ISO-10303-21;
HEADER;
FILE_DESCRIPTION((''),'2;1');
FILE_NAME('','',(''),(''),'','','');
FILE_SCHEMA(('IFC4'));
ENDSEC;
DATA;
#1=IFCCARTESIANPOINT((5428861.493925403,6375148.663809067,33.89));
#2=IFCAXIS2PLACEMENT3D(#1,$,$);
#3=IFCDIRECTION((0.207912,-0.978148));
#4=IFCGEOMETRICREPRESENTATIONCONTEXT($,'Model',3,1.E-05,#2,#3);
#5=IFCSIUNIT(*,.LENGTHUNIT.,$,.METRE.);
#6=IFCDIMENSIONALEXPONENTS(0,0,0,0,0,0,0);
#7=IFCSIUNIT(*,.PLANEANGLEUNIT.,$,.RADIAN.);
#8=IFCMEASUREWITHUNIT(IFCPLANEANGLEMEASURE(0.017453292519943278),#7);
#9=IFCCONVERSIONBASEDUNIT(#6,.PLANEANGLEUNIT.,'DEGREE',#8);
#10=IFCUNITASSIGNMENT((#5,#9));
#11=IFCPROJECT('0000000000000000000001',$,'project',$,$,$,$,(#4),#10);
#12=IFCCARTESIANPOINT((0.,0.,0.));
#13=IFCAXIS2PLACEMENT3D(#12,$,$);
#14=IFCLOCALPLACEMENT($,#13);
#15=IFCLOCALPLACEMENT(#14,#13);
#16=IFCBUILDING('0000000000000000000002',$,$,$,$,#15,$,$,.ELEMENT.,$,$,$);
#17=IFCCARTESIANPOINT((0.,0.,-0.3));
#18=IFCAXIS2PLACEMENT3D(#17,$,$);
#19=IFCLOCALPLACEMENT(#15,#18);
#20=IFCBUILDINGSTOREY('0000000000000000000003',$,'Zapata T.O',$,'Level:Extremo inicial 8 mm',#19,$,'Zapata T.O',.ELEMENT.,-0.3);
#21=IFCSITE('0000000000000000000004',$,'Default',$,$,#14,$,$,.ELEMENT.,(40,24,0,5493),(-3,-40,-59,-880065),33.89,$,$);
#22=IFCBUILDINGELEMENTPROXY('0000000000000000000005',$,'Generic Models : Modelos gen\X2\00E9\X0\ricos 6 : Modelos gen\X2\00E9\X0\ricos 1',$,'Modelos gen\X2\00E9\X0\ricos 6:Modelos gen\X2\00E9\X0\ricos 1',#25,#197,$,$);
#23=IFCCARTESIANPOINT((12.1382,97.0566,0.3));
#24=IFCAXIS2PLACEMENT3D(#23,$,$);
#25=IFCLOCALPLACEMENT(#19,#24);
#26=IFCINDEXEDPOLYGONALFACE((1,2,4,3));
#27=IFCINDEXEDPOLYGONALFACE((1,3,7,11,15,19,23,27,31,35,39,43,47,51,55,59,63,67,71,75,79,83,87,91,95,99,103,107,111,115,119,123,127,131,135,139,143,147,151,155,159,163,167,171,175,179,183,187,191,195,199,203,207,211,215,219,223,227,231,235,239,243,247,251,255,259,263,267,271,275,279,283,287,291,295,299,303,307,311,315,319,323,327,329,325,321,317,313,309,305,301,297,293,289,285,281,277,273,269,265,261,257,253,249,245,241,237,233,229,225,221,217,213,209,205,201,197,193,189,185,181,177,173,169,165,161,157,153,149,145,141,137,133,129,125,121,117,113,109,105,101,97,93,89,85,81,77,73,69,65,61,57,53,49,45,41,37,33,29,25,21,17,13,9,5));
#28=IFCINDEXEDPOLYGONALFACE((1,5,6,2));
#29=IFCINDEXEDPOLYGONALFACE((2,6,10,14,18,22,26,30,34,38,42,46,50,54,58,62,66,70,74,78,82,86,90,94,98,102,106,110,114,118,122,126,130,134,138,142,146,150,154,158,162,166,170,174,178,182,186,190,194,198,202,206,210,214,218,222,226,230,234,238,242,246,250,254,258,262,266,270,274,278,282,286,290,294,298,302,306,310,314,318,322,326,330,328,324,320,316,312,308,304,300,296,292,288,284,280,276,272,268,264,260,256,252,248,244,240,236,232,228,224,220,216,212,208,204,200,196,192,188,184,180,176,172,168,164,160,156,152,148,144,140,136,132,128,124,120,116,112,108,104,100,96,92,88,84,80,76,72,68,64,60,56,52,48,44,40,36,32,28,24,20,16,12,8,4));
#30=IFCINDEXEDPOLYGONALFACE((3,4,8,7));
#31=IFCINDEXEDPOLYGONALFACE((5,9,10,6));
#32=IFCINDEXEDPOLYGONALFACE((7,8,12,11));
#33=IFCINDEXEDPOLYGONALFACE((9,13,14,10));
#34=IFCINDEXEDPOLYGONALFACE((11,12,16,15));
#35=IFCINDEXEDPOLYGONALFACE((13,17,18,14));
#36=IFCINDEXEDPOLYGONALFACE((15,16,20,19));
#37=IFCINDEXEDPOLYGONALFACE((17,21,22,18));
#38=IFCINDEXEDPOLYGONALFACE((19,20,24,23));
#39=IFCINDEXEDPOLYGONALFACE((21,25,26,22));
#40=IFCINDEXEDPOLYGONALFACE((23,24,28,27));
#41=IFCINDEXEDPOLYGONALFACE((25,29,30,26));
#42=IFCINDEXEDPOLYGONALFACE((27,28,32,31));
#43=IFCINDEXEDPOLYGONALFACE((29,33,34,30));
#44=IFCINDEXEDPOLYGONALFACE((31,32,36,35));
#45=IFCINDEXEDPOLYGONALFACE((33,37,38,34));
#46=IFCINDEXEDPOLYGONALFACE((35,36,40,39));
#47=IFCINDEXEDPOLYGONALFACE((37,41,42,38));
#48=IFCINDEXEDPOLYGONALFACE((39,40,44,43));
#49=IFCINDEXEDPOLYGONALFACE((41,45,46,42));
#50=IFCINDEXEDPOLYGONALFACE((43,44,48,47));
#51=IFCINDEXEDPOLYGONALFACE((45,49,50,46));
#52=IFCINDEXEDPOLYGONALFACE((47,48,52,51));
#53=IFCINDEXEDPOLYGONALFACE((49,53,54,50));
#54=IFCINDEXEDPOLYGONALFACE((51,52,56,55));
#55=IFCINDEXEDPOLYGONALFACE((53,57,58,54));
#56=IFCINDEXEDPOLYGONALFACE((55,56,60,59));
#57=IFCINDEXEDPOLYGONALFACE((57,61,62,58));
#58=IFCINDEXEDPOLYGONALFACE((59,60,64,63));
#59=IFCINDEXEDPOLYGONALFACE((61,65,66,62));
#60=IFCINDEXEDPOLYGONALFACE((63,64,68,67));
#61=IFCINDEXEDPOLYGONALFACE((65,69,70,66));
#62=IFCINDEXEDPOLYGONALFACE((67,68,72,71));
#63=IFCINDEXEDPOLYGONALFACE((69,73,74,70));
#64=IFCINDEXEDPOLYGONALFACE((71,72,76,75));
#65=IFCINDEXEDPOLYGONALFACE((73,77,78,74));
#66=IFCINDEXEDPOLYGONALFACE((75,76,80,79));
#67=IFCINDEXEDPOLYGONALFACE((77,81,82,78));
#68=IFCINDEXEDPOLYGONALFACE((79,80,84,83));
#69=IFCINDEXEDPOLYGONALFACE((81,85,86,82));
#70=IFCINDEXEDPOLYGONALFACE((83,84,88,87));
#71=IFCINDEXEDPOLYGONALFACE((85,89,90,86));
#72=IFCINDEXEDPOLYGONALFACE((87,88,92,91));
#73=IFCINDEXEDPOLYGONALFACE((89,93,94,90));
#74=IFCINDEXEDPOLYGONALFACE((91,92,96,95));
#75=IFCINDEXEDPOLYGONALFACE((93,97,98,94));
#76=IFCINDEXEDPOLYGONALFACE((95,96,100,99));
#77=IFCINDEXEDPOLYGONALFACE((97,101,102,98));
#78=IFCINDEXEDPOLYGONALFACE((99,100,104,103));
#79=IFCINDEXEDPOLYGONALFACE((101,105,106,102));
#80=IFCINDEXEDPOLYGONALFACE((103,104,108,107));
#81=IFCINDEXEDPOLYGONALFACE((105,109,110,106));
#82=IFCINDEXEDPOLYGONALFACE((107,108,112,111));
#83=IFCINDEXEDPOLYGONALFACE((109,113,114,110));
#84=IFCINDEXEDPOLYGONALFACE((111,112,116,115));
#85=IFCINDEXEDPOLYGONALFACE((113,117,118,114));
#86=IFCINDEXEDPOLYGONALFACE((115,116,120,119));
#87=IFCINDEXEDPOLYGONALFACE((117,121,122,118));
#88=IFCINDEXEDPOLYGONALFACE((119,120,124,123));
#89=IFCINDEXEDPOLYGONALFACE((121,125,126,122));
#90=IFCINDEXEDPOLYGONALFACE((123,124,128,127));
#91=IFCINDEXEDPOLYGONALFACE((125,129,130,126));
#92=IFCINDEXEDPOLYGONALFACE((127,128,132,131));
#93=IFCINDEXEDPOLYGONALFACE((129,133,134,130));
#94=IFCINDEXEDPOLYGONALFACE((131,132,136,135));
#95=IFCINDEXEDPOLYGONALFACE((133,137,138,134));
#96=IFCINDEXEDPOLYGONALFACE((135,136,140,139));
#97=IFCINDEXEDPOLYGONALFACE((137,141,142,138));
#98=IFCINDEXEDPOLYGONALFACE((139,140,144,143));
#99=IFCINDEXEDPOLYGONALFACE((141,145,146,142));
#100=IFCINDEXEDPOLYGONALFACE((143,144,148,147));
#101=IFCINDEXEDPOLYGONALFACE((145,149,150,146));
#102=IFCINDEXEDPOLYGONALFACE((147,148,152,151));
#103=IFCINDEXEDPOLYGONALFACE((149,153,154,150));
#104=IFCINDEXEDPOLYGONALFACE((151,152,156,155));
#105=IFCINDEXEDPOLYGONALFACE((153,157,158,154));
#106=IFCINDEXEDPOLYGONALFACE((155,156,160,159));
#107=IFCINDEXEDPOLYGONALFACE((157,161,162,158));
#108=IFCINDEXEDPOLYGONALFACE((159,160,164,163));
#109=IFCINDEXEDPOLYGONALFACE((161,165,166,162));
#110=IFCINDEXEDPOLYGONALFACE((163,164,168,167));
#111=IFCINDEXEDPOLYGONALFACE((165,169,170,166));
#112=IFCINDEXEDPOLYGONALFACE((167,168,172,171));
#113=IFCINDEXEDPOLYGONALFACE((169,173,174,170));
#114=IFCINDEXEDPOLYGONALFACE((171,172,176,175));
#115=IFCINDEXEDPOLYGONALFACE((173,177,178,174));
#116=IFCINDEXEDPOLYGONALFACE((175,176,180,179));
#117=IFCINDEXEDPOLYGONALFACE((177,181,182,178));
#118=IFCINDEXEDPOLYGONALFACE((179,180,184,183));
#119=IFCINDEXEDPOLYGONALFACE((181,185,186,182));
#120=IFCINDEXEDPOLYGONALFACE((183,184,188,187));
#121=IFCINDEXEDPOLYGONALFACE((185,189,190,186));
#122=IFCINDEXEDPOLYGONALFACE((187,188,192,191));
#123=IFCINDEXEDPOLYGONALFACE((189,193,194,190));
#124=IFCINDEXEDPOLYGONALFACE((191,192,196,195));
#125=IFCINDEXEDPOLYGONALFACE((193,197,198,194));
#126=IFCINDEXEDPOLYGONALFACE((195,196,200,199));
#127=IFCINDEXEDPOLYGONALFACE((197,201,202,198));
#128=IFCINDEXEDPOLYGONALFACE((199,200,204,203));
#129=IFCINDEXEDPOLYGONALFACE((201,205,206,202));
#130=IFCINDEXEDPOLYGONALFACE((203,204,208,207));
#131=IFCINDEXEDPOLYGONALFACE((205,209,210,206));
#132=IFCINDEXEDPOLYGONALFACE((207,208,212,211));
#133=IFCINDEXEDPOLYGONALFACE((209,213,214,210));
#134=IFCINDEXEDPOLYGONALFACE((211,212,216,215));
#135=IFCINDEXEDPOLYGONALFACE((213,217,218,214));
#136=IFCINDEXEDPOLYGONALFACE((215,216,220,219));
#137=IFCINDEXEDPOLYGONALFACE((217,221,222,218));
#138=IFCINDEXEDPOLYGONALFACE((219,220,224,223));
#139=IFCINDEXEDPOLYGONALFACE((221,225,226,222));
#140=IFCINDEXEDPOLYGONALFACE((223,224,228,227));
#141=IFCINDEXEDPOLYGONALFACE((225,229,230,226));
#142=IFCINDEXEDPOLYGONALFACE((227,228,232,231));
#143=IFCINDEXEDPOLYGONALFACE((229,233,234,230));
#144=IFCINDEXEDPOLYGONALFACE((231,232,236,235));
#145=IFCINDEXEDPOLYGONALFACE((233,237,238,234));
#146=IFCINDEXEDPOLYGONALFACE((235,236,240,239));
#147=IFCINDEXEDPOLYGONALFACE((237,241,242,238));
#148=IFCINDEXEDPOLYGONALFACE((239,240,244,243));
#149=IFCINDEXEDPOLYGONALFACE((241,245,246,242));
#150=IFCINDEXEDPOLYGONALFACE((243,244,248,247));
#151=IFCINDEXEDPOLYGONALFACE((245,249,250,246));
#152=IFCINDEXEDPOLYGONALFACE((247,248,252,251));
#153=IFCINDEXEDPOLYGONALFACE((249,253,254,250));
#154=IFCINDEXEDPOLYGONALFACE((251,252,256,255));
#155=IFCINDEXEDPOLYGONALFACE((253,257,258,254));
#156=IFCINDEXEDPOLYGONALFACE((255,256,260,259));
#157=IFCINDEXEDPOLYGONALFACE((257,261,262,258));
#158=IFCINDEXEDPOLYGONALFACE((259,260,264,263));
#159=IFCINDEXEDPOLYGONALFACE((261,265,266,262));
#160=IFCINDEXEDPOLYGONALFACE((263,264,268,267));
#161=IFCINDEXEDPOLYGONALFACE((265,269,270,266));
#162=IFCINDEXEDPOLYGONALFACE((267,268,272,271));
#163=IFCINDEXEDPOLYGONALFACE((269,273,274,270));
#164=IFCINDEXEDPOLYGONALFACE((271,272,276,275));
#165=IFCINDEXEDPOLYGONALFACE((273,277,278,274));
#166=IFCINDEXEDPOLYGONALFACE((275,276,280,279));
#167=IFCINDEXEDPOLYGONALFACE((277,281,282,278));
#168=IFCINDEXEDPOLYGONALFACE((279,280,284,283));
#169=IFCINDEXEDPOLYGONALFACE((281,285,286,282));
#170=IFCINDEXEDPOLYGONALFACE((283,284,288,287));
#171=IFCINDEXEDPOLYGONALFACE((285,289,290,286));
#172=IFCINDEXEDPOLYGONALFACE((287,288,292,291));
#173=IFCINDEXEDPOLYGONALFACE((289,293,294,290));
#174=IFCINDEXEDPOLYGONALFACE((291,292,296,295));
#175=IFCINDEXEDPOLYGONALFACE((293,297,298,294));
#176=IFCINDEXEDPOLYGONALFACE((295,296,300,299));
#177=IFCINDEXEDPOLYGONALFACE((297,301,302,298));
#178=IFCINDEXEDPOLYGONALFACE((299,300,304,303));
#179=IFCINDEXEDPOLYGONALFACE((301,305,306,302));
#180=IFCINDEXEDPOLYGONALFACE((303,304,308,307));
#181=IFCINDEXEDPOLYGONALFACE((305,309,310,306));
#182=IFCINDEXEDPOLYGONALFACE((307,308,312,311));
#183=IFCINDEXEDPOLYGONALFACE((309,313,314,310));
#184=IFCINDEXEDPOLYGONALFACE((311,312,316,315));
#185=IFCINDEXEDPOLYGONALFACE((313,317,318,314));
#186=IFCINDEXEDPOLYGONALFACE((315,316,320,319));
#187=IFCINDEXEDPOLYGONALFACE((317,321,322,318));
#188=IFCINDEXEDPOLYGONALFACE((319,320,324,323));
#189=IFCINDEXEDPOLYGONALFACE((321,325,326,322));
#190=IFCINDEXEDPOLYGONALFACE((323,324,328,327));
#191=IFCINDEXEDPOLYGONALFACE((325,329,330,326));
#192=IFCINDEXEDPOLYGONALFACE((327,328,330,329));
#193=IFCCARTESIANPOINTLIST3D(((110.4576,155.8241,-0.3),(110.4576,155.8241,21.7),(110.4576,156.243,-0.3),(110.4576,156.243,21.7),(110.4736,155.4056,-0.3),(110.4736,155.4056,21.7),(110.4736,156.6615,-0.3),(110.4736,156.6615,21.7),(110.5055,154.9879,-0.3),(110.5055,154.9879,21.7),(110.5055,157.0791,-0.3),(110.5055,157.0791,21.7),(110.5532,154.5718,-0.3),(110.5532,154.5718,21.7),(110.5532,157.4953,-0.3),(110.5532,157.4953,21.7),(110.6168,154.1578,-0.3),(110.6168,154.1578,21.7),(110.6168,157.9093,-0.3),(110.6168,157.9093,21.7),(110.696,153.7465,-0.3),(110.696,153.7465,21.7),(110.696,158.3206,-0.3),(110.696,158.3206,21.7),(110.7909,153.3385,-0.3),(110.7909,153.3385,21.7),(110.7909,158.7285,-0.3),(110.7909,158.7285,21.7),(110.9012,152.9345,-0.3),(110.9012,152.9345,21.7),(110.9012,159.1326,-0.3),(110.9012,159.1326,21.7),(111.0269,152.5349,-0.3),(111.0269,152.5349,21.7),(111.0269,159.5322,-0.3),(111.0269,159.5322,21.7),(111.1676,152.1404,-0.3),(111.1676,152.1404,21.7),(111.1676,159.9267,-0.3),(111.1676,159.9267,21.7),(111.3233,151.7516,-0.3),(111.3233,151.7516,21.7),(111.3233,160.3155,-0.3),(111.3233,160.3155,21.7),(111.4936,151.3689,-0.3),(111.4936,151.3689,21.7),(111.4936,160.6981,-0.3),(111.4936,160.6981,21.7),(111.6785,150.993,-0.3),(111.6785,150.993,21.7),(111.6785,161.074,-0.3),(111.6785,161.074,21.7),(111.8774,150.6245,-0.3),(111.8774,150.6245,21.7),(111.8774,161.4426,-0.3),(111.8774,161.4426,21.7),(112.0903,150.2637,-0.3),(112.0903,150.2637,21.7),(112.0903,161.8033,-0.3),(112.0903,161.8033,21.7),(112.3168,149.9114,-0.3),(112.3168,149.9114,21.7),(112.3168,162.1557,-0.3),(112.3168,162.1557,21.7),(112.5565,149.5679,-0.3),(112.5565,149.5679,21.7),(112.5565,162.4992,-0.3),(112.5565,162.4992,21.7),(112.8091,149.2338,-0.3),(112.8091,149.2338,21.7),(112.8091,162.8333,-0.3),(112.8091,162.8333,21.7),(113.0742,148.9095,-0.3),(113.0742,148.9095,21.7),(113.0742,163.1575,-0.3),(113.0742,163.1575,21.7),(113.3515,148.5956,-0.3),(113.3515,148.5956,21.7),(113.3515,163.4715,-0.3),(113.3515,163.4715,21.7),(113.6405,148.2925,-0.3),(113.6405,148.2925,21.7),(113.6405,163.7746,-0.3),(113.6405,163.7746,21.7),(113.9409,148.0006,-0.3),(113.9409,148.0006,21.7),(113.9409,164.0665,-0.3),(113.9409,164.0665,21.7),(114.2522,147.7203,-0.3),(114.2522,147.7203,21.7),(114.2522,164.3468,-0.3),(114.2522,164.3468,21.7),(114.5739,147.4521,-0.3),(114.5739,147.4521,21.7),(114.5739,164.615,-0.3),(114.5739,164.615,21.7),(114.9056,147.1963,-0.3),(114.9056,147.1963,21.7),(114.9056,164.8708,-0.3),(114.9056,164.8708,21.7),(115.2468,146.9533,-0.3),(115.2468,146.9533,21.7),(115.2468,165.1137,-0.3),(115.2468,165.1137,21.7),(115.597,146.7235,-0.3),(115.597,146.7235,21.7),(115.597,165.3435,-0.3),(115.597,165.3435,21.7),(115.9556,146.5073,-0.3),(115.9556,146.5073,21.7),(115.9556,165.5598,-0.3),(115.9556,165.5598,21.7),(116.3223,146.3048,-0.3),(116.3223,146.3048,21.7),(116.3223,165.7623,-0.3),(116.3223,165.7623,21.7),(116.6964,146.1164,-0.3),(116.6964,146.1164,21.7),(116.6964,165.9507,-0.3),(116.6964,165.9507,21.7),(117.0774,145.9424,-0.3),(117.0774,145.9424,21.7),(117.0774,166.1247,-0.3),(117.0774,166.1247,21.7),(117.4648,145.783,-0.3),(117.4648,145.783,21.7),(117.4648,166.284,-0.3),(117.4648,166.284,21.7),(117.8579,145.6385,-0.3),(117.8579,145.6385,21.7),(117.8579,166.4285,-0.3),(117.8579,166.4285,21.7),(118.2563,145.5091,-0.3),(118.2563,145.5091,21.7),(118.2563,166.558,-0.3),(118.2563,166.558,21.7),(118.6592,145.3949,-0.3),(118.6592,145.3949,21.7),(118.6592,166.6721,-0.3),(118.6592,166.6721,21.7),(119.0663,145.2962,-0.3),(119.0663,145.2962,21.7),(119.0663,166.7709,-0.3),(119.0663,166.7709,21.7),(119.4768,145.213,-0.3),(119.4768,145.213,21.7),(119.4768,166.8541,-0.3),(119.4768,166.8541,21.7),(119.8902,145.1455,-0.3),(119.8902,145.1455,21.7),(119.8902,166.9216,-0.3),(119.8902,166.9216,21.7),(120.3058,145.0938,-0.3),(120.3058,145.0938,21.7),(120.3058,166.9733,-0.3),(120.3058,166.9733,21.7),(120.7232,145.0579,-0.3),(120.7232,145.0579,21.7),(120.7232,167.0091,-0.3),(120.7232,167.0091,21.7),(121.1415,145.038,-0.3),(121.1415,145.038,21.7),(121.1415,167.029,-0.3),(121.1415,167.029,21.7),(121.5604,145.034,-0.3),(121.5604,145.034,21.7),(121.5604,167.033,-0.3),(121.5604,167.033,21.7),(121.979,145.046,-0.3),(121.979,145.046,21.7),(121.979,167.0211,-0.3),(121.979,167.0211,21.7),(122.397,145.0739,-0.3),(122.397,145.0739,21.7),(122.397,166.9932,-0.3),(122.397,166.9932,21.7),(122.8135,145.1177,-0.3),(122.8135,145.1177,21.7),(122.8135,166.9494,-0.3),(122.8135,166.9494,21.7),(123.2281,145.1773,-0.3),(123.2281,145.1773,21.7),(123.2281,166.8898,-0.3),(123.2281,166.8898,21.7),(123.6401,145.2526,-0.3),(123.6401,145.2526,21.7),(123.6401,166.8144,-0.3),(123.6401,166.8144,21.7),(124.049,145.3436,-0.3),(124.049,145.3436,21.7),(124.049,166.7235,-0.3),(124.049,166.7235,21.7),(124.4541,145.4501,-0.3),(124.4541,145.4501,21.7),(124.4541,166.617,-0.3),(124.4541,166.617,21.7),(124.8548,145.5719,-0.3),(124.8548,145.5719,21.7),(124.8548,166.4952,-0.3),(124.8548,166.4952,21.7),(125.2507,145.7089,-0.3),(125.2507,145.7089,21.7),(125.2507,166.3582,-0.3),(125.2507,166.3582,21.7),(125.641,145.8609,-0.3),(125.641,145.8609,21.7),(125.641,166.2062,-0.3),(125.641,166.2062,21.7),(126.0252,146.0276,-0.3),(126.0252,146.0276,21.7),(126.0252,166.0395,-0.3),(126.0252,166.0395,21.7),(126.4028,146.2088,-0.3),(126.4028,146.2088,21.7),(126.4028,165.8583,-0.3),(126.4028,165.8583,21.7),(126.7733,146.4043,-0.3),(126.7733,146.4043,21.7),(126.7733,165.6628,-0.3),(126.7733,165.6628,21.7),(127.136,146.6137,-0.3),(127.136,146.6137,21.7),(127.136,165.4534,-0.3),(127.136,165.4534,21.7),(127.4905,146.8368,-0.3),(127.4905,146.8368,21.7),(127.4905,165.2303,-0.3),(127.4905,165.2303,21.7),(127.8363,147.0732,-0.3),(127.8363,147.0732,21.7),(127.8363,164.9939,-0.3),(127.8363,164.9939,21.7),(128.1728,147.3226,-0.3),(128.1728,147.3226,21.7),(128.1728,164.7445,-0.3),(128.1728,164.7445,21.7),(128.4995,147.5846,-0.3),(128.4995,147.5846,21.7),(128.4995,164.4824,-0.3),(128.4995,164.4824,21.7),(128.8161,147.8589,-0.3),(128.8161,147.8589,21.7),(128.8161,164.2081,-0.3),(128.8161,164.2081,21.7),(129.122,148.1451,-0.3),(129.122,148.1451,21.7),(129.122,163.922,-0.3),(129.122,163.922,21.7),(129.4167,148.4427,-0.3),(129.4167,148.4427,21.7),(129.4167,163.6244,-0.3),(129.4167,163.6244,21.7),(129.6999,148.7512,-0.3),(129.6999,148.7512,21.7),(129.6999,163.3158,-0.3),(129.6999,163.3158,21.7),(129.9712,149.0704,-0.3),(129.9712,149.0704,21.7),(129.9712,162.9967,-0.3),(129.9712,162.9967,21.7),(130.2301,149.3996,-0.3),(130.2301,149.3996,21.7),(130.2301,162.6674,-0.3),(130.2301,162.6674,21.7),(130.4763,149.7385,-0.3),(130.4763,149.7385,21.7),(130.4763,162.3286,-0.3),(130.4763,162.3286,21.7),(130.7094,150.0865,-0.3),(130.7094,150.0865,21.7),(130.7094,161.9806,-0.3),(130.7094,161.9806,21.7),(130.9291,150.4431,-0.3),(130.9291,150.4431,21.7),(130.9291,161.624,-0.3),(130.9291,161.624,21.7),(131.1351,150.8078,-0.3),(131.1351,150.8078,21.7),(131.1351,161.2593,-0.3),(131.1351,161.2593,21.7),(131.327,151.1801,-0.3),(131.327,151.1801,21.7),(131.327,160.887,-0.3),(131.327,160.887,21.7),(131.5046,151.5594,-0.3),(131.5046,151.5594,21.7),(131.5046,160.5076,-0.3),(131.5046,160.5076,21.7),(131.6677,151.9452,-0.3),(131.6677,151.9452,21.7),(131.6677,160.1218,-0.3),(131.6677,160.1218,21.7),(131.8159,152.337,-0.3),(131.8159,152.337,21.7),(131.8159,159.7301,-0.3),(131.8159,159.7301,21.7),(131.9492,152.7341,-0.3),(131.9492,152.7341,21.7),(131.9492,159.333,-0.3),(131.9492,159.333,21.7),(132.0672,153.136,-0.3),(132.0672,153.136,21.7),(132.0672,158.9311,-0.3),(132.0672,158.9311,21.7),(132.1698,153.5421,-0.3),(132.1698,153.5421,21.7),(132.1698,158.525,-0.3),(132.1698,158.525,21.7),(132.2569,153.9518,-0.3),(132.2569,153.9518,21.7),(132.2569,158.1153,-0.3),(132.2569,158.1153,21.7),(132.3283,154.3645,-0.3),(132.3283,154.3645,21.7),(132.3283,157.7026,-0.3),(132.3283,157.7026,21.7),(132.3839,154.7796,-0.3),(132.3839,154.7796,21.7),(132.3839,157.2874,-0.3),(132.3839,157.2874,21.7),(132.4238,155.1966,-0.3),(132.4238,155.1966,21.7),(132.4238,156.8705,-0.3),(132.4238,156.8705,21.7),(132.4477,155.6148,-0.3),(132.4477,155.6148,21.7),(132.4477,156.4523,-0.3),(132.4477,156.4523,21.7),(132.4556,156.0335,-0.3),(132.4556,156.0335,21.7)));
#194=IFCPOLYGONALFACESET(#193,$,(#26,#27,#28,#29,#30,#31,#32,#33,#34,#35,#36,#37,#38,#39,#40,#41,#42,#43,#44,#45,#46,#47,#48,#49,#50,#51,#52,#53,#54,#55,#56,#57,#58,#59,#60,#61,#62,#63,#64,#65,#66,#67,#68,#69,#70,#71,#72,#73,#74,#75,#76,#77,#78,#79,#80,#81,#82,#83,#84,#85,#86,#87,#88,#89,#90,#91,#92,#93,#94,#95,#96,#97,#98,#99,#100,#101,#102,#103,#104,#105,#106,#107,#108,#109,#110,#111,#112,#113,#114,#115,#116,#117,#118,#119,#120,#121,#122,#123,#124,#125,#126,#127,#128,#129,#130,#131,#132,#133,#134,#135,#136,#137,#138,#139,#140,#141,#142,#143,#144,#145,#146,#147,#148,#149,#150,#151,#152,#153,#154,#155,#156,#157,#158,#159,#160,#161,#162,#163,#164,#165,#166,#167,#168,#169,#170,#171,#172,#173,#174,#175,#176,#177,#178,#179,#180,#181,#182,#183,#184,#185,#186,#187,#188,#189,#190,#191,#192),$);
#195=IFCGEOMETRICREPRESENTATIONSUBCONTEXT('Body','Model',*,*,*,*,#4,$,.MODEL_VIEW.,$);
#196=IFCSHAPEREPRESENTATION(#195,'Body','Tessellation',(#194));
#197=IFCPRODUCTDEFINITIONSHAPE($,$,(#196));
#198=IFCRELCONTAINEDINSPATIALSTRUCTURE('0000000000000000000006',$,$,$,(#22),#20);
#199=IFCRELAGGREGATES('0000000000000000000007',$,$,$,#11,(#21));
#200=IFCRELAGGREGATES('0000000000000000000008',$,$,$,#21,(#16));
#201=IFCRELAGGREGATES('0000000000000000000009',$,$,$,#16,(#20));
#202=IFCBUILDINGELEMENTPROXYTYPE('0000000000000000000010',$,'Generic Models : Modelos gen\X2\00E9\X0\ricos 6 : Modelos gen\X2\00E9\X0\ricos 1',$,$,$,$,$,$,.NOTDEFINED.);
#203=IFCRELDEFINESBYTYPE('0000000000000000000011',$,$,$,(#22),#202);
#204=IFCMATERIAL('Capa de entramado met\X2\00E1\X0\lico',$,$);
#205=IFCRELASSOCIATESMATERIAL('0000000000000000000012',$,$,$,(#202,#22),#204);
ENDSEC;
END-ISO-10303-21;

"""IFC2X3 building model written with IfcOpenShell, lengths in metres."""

from ifc_helpers import new_model, entity, si_unit, converted_unit, direction, frame, frame_2d, origin, place, context, subcontext, project, spatial, circle, extrude, source, transform, mapped, material, type_object, type_shapes, element, save


model = new_model("IFC2X3")

# Units and contexts
model_context = context("Model", 3, precision=1e-05, world=frame((5428861.493925403, 6375148.663809067, 33.89)), true_north=direction((0.207912, -0.978148)))
body_context = subcontext(model_context, "Body", "Model", "MODEL_VIEW")
ifc_project = project(units=[si_unit("LENGTHUNIT", "METRE"), converted_unit("PLANEANGLEUNIT", "DEGREE", entity("IfcPlaneAngleMeasure", 0.017453292519943278), si_unit("PLANEANGLEUNIT", "RADIAN"), dimensions=[0, 0, 0, 0, 0, 0, 0])], contexts=[model_context])

# Site, building, storey
site_placement = place(None, origin())
site = spatial("IfcSite", under=ifc_project, at=site_placement, Name="Default", CompositionType="ELEMENT", RefLatitude=(40, 24, 0, 5493), RefLongitude=(-3, -40, -59, -880065), RefElevation=33.89)
building_placement = place(site_placement, origin())
building = spatial("IfcBuilding", under=site, at=building_placement, CompositionType="ELEMENT")
storey_placement = place(building_placement, frame((0.0, 0.0, -0.3)))
storey = spatial("IfcBuildingStorey", under=building, at=storey_placement, Name="Zapata T.O", ObjectType="Level:Extremo inicial 8 mm", LongName="Zapata T.O", CompositionType="ELEMENT", Elevation=-0.3)

# Building element proxy
ifc_material = material(Name="Capa de entramado metálico")
building_element_proxy_type_1 = type_object("IfcBuildingElementProxyType", Name="Generic Models : Modelos genéricos 6 : Modelos genéricos 1", PredefinedType="NOTDEFINED", material=ifc_material)
shared_shape_1 = source(origin(), body_context, "Body", "SweptSolid", [
    extrude(circle(Radius=11.0, at=frame_2d((0.0, 0.0), x_axis=(1.0, 0.0))), frame((121.4556, 156.0335, -0.3)), (0.0, 0.0, 1.0), 22.0),
])
type_shapes(building_element_proxy_type_1, [shared_shape_1])
proxy_1_placement = place(storey_placement, frame((12.1382, 97.0566, 0.3)))
element("IfcBuildingElementProxy", 1, at=proxy_1_placement, inside=storey, type_object=building_element_proxy_type_1, material=ifc_material, Name="Generic Models : Modelos genéricos 6 : Modelos genéricos 1", ObjectType="Modelos genéricos 6:Modelos genéricos 1", context=body_context, shape_type="MappedRepresentation", body=[
    mapped(shared_shape_1, transform((0.0, 0.0, 0.0), scale=1.0)),
])

save(model, "model.ifc")
